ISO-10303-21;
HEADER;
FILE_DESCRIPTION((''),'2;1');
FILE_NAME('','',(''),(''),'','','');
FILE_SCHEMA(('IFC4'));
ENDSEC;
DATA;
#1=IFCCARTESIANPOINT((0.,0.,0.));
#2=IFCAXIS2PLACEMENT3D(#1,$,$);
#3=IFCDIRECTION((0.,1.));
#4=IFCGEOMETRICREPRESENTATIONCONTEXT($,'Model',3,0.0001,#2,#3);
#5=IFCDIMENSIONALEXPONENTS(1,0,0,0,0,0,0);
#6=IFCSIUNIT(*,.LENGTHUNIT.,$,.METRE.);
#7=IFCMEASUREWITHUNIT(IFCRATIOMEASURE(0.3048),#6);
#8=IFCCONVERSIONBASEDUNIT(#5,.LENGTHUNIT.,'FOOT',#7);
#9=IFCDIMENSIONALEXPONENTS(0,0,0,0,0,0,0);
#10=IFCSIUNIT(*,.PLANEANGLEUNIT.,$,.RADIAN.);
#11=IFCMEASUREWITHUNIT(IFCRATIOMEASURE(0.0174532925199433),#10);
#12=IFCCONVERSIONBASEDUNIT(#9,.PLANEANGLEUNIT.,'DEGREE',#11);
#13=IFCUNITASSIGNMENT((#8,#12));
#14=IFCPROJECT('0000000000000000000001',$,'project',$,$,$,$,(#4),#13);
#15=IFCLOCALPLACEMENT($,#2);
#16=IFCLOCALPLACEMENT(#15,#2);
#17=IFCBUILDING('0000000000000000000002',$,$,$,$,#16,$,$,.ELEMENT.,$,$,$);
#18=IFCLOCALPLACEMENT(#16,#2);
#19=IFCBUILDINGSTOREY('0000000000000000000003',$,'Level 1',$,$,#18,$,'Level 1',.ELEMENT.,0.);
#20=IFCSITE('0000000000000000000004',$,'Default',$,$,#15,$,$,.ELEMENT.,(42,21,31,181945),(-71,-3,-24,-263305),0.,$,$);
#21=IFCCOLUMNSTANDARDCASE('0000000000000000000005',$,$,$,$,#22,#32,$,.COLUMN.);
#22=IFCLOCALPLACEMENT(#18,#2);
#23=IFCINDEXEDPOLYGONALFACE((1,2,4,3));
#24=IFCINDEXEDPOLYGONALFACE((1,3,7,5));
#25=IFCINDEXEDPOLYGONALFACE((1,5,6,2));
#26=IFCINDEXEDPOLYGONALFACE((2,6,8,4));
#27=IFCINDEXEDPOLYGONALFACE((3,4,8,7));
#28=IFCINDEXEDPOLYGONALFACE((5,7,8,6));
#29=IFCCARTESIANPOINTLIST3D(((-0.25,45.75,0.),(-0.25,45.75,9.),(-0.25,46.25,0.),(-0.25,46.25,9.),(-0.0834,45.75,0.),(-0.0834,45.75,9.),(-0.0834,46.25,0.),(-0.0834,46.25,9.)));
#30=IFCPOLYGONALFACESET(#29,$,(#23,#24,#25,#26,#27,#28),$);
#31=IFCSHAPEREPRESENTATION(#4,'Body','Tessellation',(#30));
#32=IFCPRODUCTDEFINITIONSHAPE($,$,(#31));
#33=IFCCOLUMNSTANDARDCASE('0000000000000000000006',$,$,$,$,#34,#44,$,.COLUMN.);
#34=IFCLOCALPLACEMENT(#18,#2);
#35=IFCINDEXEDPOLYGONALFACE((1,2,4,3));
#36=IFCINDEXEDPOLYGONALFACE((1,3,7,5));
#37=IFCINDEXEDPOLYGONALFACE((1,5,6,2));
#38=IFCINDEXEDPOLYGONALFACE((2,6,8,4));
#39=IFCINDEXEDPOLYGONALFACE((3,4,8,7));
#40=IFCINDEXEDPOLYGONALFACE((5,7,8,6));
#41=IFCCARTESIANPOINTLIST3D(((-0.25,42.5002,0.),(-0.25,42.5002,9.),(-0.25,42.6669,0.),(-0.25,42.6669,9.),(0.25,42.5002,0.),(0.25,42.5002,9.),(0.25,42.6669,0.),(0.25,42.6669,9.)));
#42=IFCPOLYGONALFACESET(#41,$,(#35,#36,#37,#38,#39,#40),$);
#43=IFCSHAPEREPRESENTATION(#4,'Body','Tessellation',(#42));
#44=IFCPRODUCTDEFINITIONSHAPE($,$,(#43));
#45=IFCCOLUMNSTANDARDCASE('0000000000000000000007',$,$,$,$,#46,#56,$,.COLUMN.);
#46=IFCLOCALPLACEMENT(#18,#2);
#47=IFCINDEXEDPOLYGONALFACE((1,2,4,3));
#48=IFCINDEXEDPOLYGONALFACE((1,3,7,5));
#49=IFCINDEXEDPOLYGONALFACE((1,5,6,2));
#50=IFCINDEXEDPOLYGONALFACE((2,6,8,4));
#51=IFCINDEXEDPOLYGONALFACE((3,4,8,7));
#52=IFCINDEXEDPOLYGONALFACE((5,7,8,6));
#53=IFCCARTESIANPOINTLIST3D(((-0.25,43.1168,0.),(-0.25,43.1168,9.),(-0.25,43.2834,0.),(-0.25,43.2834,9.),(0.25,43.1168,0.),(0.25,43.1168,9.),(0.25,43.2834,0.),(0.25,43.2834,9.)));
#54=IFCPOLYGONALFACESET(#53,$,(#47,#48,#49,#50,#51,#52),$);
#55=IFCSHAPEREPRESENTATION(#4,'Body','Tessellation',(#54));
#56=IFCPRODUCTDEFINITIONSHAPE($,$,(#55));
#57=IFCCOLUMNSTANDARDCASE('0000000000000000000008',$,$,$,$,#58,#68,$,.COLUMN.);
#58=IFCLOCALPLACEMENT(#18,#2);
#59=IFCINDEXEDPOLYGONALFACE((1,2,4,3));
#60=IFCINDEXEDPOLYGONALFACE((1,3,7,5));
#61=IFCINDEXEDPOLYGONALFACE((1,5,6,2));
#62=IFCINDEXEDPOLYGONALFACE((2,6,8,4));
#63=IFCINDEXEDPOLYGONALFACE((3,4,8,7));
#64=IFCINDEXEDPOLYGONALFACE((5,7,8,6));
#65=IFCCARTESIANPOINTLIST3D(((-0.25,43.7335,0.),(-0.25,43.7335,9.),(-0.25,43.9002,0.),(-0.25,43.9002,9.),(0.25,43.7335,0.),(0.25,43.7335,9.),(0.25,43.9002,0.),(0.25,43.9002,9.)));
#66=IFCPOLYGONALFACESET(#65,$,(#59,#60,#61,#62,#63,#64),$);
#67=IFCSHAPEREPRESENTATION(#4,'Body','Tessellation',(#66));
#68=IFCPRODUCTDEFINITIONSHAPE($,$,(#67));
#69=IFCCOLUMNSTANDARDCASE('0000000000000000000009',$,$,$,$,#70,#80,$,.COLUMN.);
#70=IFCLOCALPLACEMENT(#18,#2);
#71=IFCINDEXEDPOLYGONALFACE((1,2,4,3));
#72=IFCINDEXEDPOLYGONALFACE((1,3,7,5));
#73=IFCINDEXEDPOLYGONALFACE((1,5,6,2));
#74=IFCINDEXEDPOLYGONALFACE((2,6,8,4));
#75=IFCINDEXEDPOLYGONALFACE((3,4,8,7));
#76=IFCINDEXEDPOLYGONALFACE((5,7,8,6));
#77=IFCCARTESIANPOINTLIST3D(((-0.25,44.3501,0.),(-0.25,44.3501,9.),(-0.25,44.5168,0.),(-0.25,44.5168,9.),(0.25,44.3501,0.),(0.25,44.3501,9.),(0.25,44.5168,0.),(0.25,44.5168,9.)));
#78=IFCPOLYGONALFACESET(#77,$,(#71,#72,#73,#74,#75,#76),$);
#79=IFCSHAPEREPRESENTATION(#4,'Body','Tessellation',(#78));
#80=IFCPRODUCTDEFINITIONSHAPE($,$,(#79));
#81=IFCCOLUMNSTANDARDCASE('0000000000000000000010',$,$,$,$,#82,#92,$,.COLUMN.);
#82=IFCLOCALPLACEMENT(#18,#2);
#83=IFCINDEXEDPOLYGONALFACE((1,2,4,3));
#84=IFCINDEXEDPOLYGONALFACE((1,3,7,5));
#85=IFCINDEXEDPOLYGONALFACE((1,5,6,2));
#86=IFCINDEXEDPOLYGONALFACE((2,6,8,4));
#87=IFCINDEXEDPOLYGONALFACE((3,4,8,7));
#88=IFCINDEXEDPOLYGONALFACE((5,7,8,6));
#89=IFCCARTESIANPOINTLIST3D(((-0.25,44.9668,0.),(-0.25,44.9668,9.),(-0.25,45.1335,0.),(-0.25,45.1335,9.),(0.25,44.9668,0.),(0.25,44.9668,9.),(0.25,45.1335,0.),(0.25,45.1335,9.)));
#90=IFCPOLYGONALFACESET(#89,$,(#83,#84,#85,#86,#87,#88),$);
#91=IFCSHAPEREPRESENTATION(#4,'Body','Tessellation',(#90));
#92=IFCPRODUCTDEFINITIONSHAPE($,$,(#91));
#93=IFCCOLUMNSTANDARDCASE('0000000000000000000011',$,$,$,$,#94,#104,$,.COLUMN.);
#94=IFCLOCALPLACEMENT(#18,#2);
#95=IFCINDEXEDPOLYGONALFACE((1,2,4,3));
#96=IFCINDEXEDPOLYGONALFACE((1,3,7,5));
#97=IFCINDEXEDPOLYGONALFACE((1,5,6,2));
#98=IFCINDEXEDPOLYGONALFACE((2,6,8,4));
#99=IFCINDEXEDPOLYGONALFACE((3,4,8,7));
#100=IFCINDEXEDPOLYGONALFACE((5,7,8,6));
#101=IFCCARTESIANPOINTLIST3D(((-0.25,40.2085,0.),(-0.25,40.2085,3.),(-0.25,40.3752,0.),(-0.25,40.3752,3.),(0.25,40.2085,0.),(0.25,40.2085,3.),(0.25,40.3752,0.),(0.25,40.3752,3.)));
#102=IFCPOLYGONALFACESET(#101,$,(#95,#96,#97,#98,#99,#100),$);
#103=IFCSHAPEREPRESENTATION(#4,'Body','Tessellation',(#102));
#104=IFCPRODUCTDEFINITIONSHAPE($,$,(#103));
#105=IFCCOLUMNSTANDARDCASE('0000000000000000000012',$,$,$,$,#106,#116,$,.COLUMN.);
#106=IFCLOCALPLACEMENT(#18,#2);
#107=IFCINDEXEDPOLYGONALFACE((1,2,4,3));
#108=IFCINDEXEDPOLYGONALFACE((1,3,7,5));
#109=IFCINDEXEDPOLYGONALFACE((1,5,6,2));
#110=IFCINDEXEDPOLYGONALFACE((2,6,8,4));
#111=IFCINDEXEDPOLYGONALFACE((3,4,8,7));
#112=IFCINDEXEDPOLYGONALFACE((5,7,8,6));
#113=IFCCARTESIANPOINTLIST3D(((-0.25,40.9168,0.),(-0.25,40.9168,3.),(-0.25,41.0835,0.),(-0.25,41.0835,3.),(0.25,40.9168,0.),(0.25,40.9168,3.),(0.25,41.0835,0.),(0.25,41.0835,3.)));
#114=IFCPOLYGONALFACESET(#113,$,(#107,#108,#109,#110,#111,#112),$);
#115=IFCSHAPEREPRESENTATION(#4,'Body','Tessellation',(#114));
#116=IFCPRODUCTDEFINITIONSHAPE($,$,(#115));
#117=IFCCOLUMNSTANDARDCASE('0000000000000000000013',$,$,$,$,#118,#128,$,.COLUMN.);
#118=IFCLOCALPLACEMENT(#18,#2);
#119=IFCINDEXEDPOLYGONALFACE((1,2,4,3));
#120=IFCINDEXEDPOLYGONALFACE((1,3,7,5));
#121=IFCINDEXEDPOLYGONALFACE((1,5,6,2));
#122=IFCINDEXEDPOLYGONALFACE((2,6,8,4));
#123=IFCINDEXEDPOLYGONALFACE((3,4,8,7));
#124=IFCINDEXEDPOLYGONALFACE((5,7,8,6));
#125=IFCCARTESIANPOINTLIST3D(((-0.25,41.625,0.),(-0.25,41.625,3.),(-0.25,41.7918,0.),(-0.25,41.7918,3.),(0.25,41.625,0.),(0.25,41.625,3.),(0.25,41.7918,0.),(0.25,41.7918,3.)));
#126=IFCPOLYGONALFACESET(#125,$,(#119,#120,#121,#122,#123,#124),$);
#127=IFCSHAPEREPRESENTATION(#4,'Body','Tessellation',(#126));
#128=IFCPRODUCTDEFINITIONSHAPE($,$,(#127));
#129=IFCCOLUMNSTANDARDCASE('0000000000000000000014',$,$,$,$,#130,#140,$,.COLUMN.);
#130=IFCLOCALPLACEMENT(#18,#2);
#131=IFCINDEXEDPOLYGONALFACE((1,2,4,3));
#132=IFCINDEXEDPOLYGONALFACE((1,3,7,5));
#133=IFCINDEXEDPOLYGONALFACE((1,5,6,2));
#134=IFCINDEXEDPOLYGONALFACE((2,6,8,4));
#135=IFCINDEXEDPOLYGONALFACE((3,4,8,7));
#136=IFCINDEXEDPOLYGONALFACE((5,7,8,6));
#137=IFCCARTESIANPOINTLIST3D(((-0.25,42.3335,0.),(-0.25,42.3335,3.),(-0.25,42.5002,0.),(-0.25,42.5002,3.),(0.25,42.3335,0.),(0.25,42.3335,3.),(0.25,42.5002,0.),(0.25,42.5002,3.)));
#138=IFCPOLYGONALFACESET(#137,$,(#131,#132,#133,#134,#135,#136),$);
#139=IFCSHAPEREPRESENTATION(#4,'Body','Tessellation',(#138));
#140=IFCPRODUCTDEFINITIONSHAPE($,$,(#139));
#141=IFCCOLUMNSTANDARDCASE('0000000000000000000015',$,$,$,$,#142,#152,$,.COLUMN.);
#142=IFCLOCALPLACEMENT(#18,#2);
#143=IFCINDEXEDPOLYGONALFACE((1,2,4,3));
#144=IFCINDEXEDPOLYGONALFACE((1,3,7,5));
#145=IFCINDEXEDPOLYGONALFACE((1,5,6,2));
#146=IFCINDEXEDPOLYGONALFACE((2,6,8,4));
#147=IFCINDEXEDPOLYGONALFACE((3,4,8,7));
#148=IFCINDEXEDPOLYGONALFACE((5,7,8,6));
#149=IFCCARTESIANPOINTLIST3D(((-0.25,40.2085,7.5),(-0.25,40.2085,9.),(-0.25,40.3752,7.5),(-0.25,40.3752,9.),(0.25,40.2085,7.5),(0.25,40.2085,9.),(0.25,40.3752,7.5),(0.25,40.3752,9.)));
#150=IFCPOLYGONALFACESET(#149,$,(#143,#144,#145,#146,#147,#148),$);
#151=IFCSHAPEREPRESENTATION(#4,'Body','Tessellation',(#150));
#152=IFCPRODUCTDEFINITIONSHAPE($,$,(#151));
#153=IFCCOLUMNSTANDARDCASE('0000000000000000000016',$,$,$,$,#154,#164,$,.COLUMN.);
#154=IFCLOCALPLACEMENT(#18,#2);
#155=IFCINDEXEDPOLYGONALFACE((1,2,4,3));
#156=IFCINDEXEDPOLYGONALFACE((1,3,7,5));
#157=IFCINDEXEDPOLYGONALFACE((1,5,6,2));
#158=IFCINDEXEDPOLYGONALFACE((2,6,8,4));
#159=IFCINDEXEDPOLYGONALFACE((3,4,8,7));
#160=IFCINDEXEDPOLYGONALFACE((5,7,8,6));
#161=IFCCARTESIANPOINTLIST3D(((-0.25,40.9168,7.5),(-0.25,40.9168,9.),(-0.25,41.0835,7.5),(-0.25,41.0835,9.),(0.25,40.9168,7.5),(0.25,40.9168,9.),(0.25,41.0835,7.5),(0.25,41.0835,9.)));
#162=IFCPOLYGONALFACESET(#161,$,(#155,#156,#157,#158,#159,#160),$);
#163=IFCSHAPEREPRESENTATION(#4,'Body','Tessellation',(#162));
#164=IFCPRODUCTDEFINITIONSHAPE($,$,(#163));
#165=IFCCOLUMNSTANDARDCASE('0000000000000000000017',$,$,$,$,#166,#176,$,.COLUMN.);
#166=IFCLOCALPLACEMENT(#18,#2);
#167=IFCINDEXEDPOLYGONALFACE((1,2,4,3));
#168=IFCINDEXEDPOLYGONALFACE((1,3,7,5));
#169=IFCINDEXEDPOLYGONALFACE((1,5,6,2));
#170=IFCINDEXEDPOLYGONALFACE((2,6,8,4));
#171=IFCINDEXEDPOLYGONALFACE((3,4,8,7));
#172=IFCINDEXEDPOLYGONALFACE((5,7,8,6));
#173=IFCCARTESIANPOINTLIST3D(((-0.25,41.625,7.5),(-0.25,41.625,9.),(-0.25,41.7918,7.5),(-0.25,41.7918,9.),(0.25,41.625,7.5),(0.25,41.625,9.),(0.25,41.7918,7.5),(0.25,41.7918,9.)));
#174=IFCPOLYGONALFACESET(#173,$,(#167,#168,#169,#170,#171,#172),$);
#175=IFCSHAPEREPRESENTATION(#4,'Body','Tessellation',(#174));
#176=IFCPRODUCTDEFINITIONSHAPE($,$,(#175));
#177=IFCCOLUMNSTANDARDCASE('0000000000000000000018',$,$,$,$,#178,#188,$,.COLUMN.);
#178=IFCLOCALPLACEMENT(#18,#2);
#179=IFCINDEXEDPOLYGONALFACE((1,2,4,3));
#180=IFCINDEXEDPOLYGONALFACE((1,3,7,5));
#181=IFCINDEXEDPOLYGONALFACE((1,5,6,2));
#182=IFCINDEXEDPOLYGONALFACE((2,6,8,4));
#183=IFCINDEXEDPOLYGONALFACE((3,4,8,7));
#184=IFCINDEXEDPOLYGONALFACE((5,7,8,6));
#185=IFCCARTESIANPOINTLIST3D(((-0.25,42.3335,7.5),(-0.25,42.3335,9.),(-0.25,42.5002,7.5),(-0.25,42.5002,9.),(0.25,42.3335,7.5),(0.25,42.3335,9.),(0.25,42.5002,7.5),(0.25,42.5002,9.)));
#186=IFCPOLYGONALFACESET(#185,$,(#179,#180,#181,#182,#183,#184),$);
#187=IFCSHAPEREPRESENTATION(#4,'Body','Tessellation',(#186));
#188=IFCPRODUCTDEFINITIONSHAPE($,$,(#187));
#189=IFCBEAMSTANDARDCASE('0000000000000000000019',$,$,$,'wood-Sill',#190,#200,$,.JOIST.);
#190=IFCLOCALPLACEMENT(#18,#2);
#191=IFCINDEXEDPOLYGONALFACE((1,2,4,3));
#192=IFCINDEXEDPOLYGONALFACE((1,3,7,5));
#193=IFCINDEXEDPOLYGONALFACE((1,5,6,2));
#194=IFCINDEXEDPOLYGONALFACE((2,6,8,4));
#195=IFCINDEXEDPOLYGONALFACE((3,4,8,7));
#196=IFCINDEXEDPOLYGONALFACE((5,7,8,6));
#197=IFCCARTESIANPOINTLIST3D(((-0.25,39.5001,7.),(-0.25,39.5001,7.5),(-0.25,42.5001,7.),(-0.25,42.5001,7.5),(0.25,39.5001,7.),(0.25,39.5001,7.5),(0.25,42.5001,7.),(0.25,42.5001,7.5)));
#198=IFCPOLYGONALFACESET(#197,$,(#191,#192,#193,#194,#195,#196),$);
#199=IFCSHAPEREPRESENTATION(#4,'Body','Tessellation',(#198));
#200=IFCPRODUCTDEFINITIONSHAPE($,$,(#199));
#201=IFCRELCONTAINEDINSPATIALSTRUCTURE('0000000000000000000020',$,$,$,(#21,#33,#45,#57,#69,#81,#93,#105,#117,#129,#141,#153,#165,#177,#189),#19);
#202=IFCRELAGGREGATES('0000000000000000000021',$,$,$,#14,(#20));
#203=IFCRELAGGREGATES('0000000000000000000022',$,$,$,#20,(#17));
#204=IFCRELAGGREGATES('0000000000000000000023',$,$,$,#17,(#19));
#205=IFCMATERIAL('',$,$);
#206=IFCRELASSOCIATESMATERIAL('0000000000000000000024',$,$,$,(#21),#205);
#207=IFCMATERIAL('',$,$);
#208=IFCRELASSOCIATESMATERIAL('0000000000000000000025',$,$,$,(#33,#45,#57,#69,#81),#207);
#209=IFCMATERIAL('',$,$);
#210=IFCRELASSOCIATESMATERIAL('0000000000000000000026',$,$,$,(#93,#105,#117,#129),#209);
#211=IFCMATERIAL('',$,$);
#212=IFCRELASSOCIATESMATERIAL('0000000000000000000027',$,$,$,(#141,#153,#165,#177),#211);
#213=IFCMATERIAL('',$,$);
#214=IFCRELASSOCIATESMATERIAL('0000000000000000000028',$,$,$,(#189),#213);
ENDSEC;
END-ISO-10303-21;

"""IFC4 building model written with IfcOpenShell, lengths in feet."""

from ifc_helpers import new_model, entity, si_unit, converted_unit, direction, frame, origin, place, context, project, spatial, rectangle, extrude, material, element, save


model = new_model("IFC4")

# Units and contexts
model_context = context("Model", 3, precision=0.0001, world=origin(), true_north=direction((0.0, 1.0)))
ifc_project = project(units=[converted_unit("LENGTHUNIT", "FOOT", entity("IfcRatioMeasure", 0.3048), si_unit("LENGTHUNIT", "METRE"), dimensions=[1, 0, 0, 0, 0, 0, 0]), converted_unit("PLANEANGLEUNIT", "DEGREE", entity("IfcRatioMeasure", 0.0174532925199433), si_unit("PLANEANGLEUNIT", "RADIAN"), dimensions=[0, 0, 0, 0, 0, 0, 0])], contexts=[model_context])

# Site, building, storey
site_placement = place(None, origin())
site = spatial("IfcSite", under=ifc_project, at=site_placement, Name="Default", CompositionType="ELEMENT", RefLatitude=(42, 21, 31, 181945), RefLongitude=(-71, -3, -24, -263305), RefElevation=0.0)
building_placement = place(site_placement, origin())
building = spatial("IfcBuilding", under=site, at=building_placement, CompositionType="ELEMENT")
storey_placement = place(building_placement, origin())
storey = spatial("IfcBuildingStorey", under=building, at=storey_placement, Name="Level 1", LongName="Level 1", CompositionType="ELEMENT", Elevation=0.0)

# Columns
ifc_material_1 = material(Name="")
placement_1 = place(storey_placement, frame((-0.25, 46.0, 0.0)))
column_placement = place(placement_1, frame((0.0833, 0.0, 0.0), z_axis=(0.0, 0.0, 1.0), x_axis=(1.0, 0.0, 0.0)))
element("IfcColumnStandardCase", 1, at=column_placement, inside=storey, material=ifc_material_1, PredefinedType="COLUMN", context=model_context, shape_type="SweptSolid", body=[
    extrude(rectangle(XDim=0.1667, YDim=0.5), origin(), (0.0, 0.0, 1.0), 9.0),
])
ifc_material_2 = material(Name="")
placement_2 = place(storey_placement, frame((0.0, -0.25, 0.0), z_axis=(0.0, 0.0, 1.0), x_axis=(0.0, 1.0, 0.0)))
for number, where, z_axis, x_axis in (
    (2, (42.8335, 0.0, 0.0), (0.0, 0.0, 1.0), (1.0, 0.0, 0.0)),
    (3, (43.4501, 0.0, 0.0), (0.0, 0.0, 1.0), (1.0, 0.0, 0.0)),
    (4, (44.0668, 0.0, 0.0), (0.0, 0.0, 1.0), (1.0, 0.0, 0.0)),
    (5, (44.6834, 0.0, 0.0), (0.0, 0.0, 1.0), (1.0, 0.0, 0.0)),
    (6, (45.3001, 0.0, 0.0), (0.0, 0.0, 1.0), (1.0, 0.0, 0.0)),
):
    element("IfcColumnStandardCase", number, at=place(placement_2, frame(where, z_axis=z_axis, x_axis=x_axis)), inside=storey, material=ifc_material_2, PredefinedType="COLUMN", context=model_context, shape_type="SweptSolid", body=[
        extrude(rectangle(XDim=0.1667, YDim=0.5), origin(), (0.0, 0.0, 1.0), 9.0),
    ])
ifc_material_3 = material(Name="")
for number, where, z_axis, x_axis in (
    (7, (40.5418, 0.0, 0.0), (0.0, 0.0, 1.0), (1.0, 0.0, 0.0)),
    (8, (41.2501, 0.0, 0.0), (0.0, 0.0, 1.0), (1.0, 0.0, 0.0)),
    (9, (41.9584, 0.0, 0.0), (0.0, 0.0, 1.0), (1.0, 0.0, 0.0)),
    (10, (42.6668, 0.0, 0.0), (0.0, 0.0, 1.0), (1.0, 0.0, 0.0)),
):
    element("IfcColumnStandardCase", number, at=place(placement_2, frame(where, z_axis=z_axis, x_axis=x_axis)), inside=storey, material=ifc_material_3, PredefinedType="COLUMN", context=model_context, shape_type="SweptSolid", body=[
        extrude(rectangle(XDim=0.1667, YDim=0.5), origin(), (0.0, 0.0, 1.0), 3.0),
    ])
ifc_material_4 = material(Name="")
for number, where, z_axis, x_axis in (
    (11, (40.5418, 0.0, 7.5), (0.0, 0.0, 1.0), (1.0, 0.0, 0.0)),
    (12, (41.2501, 0.0, 7.5), (0.0, 0.0, 1.0), (1.0, 0.0, 0.0)),
    (13, (41.9584, 0.0, 7.5), (0.0, 0.0, 1.0), (1.0, 0.0, 0.0)),
    (14, (42.6668, 0.0, 7.5), (0.0, 0.0, 1.0), (1.0, 0.0, 0.0)),
):
    element("IfcColumnStandardCase", number, at=place(placement_2, frame(where, z_axis=z_axis, x_axis=x_axis)), inside=storey, material=ifc_material_4, PredefinedType="COLUMN", context=model_context, shape_type="SweptSolid", body=[
        extrude(rectangle(XDim=0.1667, YDim=0.5), origin(), (0.0, 0.0, 1.0), 1.5),
    ])

# Beam
ifc_material_5 = material(Name="")
for number, where, z_axis, x_axis in (
    (15, (41.2501, 0.0, 7.0), (0.0, 0.0, 1.0), (-1.0, 0.0, 0.0)),
):
    element("IfcBeamStandardCase", number, at=place(placement_2, frame(where, z_axis=z_axis, x_axis=x_axis)), inside=storey, material=ifc_material_5, ObjectType="wood-Sill", PredefinedType="JOIST", context=model_context, shape_type="SweptSolid", body=[
        extrude(rectangle(XDim=3.0, YDim=0.5), origin(), (0.0, 0.0, 1.0), 0.5),
    ])

save(model, "model.ifc")
